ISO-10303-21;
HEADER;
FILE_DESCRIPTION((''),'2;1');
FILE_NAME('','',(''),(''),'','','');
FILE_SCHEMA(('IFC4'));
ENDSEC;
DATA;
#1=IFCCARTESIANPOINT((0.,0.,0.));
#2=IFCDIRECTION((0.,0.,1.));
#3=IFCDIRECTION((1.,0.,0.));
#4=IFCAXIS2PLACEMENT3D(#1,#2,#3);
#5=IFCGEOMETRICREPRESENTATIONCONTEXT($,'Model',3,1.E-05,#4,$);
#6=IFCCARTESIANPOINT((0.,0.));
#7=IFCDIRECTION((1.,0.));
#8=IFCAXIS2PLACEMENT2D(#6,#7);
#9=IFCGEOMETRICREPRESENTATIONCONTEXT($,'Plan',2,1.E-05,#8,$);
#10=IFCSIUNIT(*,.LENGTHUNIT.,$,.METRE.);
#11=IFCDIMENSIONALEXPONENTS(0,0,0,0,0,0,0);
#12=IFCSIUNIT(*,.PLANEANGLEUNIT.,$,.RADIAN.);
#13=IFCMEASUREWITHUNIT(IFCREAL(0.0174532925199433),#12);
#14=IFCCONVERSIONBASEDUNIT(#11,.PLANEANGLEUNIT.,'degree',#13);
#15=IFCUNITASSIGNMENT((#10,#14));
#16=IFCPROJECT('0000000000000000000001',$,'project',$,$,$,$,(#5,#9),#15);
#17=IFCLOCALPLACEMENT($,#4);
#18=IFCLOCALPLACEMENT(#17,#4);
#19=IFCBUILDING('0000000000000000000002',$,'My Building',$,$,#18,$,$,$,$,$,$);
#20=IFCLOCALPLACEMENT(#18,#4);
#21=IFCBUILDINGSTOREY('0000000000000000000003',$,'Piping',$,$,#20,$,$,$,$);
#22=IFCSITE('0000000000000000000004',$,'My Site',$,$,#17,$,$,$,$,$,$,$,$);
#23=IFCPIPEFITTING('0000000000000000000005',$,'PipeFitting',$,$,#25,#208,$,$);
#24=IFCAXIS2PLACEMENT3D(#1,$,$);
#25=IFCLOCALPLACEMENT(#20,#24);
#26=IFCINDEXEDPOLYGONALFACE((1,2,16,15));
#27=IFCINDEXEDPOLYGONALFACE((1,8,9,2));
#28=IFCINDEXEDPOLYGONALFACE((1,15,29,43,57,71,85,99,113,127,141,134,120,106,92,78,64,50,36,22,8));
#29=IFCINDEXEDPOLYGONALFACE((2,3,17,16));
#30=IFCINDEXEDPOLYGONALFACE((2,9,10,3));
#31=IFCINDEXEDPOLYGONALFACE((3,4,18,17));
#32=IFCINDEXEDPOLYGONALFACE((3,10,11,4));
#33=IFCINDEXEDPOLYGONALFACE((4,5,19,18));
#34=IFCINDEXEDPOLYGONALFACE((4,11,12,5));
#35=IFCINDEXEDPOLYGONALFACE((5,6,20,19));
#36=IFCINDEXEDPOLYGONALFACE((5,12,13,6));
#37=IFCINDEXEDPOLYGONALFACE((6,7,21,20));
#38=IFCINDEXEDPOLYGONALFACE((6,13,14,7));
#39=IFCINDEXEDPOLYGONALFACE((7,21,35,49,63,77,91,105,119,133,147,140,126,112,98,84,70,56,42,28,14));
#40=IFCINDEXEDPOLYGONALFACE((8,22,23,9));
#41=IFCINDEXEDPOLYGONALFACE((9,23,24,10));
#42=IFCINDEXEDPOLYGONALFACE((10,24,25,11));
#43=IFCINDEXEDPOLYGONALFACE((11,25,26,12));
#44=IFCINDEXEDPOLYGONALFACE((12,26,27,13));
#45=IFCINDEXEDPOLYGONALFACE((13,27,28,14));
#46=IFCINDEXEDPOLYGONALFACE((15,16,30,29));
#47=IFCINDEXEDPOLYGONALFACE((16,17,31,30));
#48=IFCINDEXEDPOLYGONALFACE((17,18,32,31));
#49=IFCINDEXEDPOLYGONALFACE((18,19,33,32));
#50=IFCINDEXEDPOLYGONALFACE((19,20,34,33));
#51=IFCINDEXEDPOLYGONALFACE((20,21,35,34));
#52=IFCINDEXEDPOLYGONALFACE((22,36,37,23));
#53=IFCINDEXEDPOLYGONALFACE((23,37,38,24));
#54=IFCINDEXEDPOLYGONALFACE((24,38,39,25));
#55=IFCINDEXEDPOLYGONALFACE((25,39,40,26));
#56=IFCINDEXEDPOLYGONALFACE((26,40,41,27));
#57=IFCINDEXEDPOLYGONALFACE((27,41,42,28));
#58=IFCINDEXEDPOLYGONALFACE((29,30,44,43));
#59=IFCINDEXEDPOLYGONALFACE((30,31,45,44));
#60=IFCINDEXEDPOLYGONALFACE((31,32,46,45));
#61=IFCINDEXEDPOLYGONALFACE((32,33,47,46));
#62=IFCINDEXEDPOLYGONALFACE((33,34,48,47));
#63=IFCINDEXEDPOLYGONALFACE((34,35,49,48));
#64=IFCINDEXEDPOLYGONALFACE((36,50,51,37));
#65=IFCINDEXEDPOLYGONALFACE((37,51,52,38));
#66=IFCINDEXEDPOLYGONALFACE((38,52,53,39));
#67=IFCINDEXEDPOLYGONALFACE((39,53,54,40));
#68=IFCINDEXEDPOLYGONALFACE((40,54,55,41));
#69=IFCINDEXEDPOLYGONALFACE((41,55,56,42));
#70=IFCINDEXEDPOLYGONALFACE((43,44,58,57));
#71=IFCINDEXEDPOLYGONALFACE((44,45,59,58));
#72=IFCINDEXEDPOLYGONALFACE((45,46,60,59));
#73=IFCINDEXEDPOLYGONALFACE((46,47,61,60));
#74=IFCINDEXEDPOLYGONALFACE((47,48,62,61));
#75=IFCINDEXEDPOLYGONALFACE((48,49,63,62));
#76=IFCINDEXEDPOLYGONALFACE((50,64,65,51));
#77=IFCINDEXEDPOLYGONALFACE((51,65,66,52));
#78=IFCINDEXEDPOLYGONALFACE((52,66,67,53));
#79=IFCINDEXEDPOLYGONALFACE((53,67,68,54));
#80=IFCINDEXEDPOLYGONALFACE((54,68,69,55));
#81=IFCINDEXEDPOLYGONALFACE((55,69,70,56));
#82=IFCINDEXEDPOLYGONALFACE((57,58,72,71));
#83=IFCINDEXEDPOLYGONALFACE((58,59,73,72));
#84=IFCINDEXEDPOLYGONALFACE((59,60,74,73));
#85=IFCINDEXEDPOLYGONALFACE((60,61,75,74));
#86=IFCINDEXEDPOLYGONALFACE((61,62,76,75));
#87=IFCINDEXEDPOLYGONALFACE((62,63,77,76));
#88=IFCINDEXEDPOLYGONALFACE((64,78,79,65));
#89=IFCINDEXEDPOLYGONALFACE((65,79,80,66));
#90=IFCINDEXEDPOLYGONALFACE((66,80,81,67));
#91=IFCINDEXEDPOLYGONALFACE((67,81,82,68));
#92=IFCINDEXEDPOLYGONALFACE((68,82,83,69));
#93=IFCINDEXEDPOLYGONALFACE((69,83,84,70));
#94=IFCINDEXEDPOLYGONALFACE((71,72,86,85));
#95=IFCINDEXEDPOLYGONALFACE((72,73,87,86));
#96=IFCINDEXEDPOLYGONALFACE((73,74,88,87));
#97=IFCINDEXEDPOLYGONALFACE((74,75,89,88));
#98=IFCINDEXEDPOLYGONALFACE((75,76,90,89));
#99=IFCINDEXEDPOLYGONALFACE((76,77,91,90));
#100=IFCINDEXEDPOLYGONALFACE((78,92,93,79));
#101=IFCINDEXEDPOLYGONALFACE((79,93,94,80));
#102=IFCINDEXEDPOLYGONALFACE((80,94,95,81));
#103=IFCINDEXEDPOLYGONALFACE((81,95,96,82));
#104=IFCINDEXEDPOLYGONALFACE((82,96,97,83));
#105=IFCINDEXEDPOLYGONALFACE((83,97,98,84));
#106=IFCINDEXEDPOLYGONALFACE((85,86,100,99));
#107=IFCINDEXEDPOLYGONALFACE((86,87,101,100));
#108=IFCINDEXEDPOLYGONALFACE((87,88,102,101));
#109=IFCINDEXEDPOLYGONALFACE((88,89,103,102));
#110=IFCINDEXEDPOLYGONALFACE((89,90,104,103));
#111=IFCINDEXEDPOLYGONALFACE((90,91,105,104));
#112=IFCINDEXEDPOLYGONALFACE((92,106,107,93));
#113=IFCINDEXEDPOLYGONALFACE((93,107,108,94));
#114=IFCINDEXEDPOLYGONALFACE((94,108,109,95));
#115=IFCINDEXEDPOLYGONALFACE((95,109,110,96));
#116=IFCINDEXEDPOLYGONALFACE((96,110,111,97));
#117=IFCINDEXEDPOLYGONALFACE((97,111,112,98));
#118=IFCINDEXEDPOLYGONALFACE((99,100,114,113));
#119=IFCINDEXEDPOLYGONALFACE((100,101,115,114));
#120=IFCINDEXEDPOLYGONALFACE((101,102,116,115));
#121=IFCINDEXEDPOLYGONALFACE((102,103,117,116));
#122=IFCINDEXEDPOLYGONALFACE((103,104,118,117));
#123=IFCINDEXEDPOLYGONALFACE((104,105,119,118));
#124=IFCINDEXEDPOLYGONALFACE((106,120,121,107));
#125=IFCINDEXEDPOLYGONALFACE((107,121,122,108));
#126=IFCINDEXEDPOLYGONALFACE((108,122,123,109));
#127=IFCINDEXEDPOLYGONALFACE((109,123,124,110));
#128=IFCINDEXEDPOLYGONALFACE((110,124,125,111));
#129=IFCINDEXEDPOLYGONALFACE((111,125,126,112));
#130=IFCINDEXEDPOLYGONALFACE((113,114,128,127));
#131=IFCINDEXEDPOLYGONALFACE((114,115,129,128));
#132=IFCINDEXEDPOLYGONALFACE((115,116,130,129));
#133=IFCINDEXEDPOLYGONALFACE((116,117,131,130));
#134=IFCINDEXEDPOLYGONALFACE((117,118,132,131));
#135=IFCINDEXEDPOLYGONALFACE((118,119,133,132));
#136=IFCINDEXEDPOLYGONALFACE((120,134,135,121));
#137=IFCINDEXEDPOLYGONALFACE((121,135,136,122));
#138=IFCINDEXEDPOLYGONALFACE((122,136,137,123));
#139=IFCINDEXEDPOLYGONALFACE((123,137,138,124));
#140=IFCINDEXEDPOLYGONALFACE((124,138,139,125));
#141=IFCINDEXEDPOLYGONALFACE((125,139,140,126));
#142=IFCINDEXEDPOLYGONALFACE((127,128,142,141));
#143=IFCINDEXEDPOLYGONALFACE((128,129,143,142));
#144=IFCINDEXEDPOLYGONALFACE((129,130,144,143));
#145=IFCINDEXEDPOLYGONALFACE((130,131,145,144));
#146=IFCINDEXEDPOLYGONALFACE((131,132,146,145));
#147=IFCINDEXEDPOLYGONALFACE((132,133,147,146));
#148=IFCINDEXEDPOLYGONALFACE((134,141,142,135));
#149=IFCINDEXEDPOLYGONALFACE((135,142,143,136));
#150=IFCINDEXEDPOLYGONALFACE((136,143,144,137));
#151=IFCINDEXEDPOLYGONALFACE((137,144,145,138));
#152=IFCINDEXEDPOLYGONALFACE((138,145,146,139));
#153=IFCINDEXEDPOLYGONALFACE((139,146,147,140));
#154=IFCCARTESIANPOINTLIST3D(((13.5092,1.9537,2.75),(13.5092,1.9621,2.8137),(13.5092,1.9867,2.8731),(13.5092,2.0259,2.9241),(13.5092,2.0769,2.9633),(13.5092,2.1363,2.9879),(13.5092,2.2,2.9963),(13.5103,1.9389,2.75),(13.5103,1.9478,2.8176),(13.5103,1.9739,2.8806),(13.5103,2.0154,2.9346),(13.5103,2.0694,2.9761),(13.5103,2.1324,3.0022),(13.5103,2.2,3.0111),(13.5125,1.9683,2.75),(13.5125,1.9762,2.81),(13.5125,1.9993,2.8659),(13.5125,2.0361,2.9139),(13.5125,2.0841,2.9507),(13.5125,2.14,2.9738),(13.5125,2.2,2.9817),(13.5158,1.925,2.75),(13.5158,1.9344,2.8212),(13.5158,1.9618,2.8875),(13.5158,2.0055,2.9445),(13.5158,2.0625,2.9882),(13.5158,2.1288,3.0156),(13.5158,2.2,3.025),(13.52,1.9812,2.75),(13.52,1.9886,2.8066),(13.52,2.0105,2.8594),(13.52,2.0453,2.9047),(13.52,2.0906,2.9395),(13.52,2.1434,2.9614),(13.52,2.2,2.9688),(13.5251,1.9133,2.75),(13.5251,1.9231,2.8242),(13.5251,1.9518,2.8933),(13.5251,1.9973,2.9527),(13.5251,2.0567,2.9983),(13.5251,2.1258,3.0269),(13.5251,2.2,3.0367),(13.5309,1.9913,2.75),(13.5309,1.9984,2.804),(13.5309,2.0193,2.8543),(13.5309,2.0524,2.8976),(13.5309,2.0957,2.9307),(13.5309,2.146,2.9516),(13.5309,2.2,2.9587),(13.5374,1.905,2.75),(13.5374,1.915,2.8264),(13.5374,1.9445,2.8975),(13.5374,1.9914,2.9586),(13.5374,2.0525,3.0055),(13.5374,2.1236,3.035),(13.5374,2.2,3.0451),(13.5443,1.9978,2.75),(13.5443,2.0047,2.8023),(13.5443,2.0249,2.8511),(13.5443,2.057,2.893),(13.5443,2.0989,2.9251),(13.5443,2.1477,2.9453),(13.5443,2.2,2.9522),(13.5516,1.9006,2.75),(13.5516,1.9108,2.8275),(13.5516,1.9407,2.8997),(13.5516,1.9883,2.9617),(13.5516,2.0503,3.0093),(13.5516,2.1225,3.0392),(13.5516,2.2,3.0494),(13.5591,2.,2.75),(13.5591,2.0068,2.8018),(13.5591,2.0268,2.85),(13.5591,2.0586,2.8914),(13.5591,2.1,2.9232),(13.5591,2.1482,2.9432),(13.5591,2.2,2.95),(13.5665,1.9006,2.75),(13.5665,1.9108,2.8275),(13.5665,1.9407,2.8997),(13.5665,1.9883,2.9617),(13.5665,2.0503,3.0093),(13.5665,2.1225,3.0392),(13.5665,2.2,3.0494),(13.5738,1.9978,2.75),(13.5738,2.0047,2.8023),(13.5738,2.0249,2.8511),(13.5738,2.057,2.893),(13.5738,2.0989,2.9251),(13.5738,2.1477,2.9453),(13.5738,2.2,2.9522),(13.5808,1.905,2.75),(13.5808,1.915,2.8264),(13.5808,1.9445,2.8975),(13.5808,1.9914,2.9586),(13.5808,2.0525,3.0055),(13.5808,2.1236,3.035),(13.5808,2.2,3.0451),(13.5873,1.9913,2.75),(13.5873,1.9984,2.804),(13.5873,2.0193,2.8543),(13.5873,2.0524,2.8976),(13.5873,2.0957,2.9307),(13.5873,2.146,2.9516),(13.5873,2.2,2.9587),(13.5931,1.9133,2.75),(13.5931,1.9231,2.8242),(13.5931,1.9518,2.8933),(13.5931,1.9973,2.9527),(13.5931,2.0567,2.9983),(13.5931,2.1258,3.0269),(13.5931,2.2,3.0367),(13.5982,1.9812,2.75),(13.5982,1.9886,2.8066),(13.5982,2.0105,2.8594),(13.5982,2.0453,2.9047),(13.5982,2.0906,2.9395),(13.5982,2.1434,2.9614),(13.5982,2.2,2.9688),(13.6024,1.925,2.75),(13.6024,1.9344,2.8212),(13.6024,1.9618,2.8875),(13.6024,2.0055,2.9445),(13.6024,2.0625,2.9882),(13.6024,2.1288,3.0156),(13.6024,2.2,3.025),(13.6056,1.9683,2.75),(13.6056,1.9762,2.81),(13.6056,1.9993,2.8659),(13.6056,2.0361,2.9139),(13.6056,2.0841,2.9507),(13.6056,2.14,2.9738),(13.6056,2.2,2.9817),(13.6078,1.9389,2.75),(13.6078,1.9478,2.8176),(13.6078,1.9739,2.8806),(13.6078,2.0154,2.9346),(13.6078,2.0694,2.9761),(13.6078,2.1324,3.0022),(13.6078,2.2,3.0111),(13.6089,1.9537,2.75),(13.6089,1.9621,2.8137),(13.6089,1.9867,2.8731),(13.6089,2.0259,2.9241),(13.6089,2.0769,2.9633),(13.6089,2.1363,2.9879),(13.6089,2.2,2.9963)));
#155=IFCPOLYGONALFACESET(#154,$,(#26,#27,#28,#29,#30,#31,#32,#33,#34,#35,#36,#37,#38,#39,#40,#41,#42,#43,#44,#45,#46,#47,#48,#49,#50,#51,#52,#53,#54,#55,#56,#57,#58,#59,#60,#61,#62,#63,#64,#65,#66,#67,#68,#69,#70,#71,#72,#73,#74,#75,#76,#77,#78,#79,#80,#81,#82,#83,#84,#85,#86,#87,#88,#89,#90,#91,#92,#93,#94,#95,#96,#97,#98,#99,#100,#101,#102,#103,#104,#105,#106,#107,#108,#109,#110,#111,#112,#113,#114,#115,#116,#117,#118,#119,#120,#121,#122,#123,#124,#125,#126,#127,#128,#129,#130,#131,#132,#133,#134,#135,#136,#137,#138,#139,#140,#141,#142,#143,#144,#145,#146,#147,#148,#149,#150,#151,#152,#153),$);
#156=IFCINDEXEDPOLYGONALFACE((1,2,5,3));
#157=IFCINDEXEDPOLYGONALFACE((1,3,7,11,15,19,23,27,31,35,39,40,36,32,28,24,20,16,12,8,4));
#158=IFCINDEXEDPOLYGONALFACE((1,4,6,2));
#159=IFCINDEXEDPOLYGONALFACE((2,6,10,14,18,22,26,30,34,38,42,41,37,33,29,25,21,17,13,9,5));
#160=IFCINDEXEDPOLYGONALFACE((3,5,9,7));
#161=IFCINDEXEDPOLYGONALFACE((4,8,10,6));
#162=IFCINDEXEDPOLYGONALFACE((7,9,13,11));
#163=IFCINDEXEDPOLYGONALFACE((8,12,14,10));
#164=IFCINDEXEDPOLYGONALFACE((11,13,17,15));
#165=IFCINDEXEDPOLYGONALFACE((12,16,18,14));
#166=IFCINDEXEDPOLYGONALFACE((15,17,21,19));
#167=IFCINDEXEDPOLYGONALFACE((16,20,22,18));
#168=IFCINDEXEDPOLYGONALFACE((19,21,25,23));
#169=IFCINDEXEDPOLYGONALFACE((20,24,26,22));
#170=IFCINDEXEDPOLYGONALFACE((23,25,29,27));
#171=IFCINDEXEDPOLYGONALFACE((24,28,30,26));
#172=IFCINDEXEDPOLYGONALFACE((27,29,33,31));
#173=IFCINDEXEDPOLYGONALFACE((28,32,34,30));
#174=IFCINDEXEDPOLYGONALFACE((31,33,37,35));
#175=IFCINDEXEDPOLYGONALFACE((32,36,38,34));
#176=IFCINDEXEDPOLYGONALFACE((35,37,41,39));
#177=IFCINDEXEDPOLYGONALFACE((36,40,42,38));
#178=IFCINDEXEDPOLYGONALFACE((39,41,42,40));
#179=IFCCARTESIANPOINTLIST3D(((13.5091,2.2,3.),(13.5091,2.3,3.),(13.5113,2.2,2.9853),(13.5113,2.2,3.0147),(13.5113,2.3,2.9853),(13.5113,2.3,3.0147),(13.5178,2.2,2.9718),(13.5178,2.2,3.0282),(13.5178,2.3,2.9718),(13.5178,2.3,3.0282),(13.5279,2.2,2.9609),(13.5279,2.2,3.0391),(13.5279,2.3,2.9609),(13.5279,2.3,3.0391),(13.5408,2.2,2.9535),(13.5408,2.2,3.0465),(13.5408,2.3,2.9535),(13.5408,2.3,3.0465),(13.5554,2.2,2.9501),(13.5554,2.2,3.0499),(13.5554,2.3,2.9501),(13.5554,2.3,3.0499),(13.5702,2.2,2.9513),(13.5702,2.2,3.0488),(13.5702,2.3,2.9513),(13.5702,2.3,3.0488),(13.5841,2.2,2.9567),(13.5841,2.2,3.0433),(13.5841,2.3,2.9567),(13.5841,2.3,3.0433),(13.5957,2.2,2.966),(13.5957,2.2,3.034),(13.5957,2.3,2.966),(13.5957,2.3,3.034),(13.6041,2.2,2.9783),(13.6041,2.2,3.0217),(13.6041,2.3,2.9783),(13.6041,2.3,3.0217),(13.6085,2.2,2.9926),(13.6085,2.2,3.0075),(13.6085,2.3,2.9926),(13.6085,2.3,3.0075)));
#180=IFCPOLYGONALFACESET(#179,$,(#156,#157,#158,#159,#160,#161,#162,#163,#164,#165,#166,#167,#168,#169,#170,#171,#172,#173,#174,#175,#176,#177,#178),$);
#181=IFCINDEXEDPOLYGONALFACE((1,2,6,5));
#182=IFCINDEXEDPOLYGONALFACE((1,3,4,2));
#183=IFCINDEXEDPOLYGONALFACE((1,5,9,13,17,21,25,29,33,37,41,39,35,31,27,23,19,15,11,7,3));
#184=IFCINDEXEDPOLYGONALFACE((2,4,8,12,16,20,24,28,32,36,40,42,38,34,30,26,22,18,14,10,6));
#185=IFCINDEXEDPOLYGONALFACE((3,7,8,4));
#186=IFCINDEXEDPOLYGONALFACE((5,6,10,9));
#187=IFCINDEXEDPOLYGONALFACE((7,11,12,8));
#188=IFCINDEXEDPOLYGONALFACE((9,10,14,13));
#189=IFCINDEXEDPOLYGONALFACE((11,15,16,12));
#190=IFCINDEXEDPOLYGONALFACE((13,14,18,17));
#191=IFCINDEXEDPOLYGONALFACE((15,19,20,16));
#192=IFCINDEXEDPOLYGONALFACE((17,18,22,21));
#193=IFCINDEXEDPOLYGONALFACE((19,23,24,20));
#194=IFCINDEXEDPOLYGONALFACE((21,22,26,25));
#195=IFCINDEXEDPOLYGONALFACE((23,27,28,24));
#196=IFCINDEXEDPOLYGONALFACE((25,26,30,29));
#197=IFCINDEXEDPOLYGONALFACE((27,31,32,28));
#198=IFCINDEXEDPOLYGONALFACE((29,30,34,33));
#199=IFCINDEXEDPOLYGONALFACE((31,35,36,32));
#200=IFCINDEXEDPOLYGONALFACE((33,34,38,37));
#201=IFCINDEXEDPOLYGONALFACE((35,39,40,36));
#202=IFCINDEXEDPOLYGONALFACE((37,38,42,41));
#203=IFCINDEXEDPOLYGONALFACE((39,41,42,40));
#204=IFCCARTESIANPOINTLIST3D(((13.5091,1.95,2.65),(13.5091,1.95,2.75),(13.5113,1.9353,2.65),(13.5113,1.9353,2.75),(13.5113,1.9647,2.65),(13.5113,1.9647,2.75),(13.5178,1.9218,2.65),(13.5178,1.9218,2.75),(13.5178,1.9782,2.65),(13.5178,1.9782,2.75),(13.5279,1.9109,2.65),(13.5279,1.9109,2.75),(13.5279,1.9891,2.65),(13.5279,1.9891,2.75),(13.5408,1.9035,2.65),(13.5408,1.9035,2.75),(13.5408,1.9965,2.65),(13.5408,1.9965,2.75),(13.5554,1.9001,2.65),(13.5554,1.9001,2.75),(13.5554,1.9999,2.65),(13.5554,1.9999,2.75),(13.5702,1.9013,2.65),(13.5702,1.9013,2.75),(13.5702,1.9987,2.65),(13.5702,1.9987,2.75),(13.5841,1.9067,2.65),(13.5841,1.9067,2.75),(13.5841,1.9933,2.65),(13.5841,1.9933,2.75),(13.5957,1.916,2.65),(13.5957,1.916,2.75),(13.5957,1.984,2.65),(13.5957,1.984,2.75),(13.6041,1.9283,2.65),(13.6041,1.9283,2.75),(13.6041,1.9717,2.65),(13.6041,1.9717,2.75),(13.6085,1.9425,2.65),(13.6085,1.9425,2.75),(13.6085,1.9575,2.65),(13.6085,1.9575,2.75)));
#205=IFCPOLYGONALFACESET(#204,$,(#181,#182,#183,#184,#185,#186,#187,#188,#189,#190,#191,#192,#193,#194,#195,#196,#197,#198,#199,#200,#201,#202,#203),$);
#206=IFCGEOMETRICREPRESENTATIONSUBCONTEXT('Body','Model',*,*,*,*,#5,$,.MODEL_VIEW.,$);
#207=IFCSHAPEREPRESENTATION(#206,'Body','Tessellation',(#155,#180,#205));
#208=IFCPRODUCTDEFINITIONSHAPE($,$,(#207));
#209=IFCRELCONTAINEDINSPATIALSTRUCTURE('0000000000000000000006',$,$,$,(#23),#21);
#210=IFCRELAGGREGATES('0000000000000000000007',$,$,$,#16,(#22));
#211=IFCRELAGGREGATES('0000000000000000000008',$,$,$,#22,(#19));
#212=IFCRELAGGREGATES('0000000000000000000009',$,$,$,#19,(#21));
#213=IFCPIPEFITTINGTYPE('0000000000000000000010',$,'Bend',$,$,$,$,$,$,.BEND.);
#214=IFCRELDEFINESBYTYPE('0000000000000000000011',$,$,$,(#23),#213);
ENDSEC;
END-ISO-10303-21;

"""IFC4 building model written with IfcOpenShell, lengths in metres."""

from ifc_helpers import new_model, entity, si_unit, converted_unit, frame, origin_with_axes, origin_2d_with_axis, place, context, subcontext, project, spatial, circle, extrude, source, transform, mapped, type_object, type_shapes, element, save


model = new_model("IFC4")

# Units and contexts
model_context = context("Model", 3, precision=1e-05, world=origin_with_axes())
plan_context = context("Plan", 2, precision=1e-05, world=origin_2d_with_axis())
body_context = subcontext(model_context, "Body", "Model", "MODEL_VIEW")
ifc_project = project(units=[si_unit("LENGTHUNIT", "METRE"), converted_unit("PLANEANGLEUNIT", "degree", entity("IfcReal", 0.0174532925199433), si_unit("PLANEANGLEUNIT", "RADIAN"), dimensions=[0, 0, 0, 0, 0, 0, 0])], contexts=[model_context, plan_context])

# Site, building, storey
site_placement = place(None, origin_with_axes())
site = spatial("IfcSite", under=ifc_project, at=site_placement, Name="My Site")
building_placement = place(site_placement, origin_with_axes())
building = spatial("IfcBuilding", under=site, at=building_placement, Name="My Building")
storey_placement = place(building_placement, origin_with_axes())
storey = spatial("IfcBuildingStorey", under=building, at=storey_placement, Name="Piping")

# Pipe fitting
pipe_fitting_type = type_object("IfcPipeFittingType", Name="Bend", PredefinedType="BEND")
shared_shape = source(origin_with_axes(), body_context, "Body", "SolidModel", [
    entity("IfcSweptDiskSolid", entity("IfcIndexedPolyCurve", entity("IfcCartesianPointList3D", [[0.0, 0.0, -0.1], [0.0, -0.0732, -0.2768], [0.0, -0.25, -0.35]]), [entity("IfcArcIndex", [1, 2, 3])]), 0.05),
    extrude(circle(Radius=0.05), origin_with_axes(), (0.0, 0.0, -1.0), 0.1),
    extrude(circle(Radius=0.05), frame((0.0, -0.25, -0.35), z_axis=(0.0, -1.0, 0.0), x_axis=(1.0, 0.0, 0.0)), (0.0, 0.0, 1.0), 0.1),
])
type_shapes(pipe_fitting_type, [shared_shape])
for number, where, z_axis, x_axis, name in (
    (1, (13.5591, 2.3, 3.0), (0.0, 1.0, 0.0), (-1.0, 0.0, 0.0), "PipeFitting"),
):
    element("IfcPipeFitting", number, at=place(storey_placement, frame(where, z_axis=z_axis, x_axis=x_axis)), inside=storey, type_object=pipe_fitting_type, Name=name, context=body_context, shape_type="MappedRepresentation", body=[
        mapped(shared_shape, transform((0.0, 0.0, 0.0), x_axis=(1.0, 0.0, 0.0), y_axis=(0.0, 1.0, 0.0), z_axis=(0.0, 0.0, 1.0), scale=1.0)),
    ])

save(model, "model.ifc")
